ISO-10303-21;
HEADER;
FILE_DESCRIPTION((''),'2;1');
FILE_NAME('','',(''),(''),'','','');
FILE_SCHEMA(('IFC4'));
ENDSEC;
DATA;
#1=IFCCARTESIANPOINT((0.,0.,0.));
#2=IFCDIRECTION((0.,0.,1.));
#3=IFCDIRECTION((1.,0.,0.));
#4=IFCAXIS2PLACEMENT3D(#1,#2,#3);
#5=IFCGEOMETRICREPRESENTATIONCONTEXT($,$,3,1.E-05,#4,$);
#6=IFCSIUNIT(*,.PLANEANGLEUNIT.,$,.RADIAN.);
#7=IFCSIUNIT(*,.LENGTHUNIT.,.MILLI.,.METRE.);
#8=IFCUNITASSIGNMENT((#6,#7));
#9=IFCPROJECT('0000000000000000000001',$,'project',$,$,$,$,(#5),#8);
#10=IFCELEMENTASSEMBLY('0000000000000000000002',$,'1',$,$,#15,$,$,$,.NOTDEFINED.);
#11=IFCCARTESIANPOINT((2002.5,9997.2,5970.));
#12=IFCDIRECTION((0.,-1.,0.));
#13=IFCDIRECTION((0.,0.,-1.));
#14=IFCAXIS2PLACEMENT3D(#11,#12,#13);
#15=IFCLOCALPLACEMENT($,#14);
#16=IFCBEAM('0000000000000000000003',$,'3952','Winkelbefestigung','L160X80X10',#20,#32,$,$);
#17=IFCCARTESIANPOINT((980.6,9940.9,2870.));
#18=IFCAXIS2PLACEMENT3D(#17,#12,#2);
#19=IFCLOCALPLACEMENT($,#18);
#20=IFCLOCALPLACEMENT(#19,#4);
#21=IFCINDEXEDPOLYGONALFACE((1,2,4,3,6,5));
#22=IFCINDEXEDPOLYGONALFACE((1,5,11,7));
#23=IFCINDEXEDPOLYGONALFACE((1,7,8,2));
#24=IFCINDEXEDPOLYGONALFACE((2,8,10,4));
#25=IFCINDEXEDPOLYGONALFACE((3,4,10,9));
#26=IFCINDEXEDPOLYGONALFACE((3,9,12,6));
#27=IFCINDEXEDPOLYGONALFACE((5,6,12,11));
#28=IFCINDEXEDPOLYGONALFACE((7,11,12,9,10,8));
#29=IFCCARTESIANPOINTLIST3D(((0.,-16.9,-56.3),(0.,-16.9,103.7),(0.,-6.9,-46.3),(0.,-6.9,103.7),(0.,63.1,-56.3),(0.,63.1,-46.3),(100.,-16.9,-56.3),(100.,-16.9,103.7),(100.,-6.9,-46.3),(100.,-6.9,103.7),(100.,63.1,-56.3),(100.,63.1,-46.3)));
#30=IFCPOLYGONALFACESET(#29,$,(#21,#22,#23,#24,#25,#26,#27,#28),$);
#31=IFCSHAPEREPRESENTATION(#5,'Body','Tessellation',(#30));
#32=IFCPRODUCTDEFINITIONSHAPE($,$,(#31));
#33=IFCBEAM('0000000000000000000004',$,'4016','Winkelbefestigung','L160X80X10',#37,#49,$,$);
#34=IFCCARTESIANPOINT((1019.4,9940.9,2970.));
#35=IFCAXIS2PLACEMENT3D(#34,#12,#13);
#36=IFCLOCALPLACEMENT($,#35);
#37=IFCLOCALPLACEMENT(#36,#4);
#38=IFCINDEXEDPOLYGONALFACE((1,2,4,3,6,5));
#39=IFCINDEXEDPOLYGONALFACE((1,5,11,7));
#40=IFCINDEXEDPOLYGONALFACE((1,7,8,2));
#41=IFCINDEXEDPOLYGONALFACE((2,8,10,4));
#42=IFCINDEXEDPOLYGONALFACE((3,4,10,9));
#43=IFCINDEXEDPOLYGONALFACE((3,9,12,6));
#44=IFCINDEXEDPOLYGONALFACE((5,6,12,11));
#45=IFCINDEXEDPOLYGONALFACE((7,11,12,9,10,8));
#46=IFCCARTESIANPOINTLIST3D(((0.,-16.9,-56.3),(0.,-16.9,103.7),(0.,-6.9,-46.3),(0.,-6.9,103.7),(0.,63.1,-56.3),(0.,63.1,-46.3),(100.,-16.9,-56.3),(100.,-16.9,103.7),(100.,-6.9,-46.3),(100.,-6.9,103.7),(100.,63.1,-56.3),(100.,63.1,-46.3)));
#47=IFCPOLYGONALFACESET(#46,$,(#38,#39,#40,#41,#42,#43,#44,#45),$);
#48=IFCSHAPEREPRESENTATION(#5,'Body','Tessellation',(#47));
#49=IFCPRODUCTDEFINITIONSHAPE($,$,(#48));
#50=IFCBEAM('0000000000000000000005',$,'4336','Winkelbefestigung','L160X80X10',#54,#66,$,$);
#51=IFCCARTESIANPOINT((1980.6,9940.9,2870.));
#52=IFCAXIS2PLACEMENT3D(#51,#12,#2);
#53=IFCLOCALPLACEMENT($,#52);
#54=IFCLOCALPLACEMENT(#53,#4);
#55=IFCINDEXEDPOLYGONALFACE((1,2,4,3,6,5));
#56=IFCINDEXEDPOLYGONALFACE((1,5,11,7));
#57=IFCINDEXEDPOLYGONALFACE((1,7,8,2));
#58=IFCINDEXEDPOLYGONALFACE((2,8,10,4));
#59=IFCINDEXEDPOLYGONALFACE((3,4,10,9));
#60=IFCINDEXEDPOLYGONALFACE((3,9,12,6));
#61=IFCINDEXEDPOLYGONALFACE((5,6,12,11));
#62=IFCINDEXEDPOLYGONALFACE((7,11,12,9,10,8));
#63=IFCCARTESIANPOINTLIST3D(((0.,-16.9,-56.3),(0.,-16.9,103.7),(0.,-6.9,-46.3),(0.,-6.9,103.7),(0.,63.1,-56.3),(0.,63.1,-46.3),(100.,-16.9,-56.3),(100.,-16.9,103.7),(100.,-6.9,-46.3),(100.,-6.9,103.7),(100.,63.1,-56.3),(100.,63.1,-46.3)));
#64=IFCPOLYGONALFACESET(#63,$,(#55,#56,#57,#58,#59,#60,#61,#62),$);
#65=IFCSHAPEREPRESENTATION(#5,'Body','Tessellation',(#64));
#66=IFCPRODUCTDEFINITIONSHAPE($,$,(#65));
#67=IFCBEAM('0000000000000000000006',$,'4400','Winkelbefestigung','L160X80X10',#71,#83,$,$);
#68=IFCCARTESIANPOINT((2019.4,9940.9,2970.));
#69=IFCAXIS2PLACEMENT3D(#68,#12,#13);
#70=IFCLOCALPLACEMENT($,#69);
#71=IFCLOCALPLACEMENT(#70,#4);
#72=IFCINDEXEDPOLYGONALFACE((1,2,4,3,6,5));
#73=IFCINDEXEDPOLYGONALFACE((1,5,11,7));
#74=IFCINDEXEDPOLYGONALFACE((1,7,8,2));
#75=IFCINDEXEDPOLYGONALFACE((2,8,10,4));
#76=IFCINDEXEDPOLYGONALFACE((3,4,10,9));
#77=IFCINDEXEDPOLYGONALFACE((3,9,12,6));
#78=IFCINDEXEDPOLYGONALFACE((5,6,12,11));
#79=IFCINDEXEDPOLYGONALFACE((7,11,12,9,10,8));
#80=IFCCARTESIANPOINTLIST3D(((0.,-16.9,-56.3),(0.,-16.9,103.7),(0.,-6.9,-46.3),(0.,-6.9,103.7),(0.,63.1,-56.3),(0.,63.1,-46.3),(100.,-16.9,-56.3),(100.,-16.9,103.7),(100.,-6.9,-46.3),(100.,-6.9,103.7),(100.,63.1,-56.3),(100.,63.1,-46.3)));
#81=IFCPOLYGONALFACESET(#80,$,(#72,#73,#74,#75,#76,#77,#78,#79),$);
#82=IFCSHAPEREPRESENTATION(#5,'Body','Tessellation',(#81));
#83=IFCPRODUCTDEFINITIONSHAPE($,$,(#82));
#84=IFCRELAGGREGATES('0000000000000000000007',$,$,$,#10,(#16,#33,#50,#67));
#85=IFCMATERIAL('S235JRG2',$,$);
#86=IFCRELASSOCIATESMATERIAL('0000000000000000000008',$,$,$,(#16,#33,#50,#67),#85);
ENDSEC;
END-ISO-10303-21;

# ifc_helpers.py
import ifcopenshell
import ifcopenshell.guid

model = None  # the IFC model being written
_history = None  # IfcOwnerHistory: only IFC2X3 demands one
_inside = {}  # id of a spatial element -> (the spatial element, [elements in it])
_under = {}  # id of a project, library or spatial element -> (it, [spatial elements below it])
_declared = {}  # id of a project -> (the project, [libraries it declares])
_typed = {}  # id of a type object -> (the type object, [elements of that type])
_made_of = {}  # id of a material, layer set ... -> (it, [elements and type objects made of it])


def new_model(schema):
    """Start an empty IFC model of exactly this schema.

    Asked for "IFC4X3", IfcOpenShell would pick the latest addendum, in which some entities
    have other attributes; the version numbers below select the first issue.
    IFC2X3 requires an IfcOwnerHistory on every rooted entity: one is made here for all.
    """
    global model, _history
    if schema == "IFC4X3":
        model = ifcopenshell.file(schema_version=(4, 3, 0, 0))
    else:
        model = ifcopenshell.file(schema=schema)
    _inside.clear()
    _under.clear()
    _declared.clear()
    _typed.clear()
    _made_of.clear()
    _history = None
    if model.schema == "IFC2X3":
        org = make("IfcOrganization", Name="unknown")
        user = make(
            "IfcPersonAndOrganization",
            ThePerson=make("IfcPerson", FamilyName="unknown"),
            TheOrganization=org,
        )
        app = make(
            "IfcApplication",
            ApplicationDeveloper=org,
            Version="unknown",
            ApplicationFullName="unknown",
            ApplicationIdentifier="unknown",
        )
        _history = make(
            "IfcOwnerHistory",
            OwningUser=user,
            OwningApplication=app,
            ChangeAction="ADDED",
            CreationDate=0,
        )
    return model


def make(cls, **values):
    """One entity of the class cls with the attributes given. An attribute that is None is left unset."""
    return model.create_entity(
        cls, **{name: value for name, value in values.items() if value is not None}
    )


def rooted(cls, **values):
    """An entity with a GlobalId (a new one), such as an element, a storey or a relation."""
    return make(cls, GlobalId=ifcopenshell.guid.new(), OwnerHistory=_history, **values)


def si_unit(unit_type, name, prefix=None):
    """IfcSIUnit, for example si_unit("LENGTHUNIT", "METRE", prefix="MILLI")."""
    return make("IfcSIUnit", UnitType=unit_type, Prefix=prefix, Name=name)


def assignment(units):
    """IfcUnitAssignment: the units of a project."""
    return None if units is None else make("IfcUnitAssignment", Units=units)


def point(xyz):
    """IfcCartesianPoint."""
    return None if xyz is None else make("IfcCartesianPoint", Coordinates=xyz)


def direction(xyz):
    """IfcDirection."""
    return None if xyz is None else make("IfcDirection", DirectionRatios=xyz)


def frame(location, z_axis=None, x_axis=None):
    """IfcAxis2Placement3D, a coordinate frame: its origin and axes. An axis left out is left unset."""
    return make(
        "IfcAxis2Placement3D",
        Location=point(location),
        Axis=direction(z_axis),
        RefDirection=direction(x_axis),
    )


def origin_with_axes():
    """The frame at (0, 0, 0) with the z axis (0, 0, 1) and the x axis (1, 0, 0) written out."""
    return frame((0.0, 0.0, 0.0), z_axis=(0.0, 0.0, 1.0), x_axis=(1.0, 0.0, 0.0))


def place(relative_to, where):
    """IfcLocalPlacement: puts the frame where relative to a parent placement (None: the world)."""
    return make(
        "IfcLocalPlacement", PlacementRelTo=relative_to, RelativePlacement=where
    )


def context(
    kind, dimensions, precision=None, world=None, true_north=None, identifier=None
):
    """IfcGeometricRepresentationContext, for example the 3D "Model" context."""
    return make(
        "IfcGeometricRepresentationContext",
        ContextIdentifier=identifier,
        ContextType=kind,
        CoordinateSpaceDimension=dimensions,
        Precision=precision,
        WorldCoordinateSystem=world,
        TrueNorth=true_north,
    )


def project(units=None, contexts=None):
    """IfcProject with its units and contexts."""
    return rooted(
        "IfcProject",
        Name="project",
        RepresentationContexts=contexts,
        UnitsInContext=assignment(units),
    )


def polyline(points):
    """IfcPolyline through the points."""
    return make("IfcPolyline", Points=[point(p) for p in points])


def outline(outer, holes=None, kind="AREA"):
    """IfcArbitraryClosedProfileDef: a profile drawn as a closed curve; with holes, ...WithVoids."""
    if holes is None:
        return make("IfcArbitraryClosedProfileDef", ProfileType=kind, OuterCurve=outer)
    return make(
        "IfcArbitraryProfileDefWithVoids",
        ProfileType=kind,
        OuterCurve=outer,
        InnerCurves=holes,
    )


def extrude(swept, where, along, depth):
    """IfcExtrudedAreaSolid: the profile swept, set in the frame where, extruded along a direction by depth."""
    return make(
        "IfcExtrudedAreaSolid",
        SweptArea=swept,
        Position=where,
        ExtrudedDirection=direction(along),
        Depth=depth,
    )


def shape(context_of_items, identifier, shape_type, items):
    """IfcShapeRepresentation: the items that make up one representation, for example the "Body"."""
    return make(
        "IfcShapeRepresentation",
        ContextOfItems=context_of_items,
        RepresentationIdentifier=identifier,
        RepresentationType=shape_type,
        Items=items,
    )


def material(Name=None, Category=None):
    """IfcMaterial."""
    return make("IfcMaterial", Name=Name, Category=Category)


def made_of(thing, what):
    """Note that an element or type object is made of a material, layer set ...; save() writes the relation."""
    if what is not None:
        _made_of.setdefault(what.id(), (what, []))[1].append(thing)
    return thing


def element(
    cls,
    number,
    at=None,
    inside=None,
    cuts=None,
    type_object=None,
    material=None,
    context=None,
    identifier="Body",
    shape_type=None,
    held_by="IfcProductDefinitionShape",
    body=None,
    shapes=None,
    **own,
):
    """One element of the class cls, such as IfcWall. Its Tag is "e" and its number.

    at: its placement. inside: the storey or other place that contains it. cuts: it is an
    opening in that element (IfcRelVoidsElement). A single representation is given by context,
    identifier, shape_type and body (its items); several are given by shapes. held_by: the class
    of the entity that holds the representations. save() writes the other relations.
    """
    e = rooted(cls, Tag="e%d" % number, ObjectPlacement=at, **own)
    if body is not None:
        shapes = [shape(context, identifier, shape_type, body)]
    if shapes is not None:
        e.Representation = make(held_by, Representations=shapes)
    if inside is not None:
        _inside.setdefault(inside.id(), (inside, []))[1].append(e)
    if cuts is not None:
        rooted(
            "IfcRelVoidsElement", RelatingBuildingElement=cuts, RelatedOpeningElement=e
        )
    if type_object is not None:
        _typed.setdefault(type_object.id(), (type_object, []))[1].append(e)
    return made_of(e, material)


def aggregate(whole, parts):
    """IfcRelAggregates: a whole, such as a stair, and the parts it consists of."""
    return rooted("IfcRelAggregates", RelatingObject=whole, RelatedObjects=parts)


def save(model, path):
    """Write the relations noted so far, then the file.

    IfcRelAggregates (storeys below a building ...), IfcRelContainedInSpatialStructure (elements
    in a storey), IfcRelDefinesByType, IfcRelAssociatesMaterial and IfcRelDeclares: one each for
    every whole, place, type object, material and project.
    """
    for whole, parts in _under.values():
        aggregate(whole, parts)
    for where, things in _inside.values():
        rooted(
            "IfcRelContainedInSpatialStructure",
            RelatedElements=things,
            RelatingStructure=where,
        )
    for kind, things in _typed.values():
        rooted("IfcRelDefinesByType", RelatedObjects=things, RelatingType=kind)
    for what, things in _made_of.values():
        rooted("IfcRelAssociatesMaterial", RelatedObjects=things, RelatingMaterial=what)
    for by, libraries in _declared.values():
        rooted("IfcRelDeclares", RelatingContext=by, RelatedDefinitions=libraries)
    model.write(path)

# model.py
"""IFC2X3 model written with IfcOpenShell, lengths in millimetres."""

from ifc_helpers import new_model, si_unit, frame, origin_with_axes, place, context, project, polyline, outline, extrude, material, element, aggregate, save


model = new_model("IFC2X3")

# Units and contexts
context_of_model = context(None, 3, precision=1e-05, world=origin_with_axes())
ifc_project = project(units=[si_unit("PLANEANGLEUNIT", "RADIAN"), si_unit("LENGTHUNIT", "METRE", prefix="MILLI")], contexts=[context_of_model])

# Element assembly, beams
assembly_1_placement = place(None, frame((2002.5, 9997.2, 5970.0), z_axis=(0.0, -1.0, 0.0), x_axis=(0.0, 0.0, -1.0)))
assembly_1 = element("IfcElementAssembly", 1, at=assembly_1_placement, Name="1", PredefinedType="NOTDEFINED")
ifc_material = material(Name="S235JRG2")
placement_1 = place(None, frame((980.6, 9940.9, 2870.0), z_axis=(0.0, -1.0, 0.0), x_axis=(0.0, 0.0, 1.0)))
beam_1_placement = place(placement_1, origin_with_axes())
beam_1 = element("IfcBeam", 2, at=beam_1_placement, material=ifc_material, Name="3952", Description="Winkelbefestigung", ObjectType="L160X80X10", context=context_of_model, shape_type="SweptSolid", body=[
    extrude(outline(polyline([(-16.9, 103.7), (-16.9, -56.3), (63.1, -56.3), (63.1, -46.3), (-6.9, -46.3), (-6.9, 103.7), (-16.9, 103.7), (-16.9, 103.7)])), frame((0.0, 0.0, 0.0), z_axis=(1.0, 0.0, 0.0), x_axis=(0.0, 1.0, 0.0)), (0.0, 0.0, 1.0), 100.0),
])
placement_2 = place(None, frame((1019.4, 9940.9, 2970.0), z_axis=(0.0, -1.0, 0.0), x_axis=(0.0, 0.0, -1.0)))
beam_2_placement = place(placement_2, origin_with_axes())
beam_2 = element("IfcBeam", 3, at=beam_2_placement, material=ifc_material, Name="4016", Description="Winkelbefestigung", ObjectType="L160X80X10", context=context_of_model, shape_type="SweptSolid", body=[
    extrude(outline(polyline([(-16.9, 103.7), (-16.9, -56.3), (63.1, -56.3), (63.1, -46.3), (-6.9, -46.3), (-6.9, 103.7), (-16.9, 103.7), (-16.9, 103.7)])), frame((0.0, 0.0, 0.0), z_axis=(1.0, 0.0, 0.0), x_axis=(0.0, 1.0, 0.0)), (0.0, 0.0, 1.0), 100.0),
])
placement_3 = place(None, frame((1980.6, 9940.9, 2870.0), z_axis=(0.0, -1.0, 0.0), x_axis=(0.0, 0.0, 1.0)))
beam_3_placement = place(placement_3, origin_with_axes())
beam_3 = element("IfcBeam", 4, at=beam_3_placement, material=ifc_material, Name="4336", Description="Winkelbefestigung", ObjectType="L160X80X10", context=context_of_model, shape_type="SweptSolid", body=[
    extrude(outline(polyline([(-16.9, 103.7), (-16.9, -56.3), (63.1, -56.3), (63.1, -46.3), (-6.9, -46.3), (-6.9, 103.7), (-16.9, 103.7), (-16.9, 103.7)])), frame((0.0, 0.0, 0.0), z_axis=(1.0, 0.0, 0.0), x_axis=(0.0, 1.0, 0.0)), (0.0, 0.0, 1.0), 100.0),
])
placement_4 = place(None, frame((2019.4, 9940.9, 2970.0), z_axis=(0.0, -1.0, 0.0), x_axis=(0.0, 0.0, -1.0)))
beam_4_placement = place(placement_4, origin_with_axes())
beam_4 = element("IfcBeam", 5, at=beam_4_placement, material=ifc_material, Name="4400", Description="Winkelbefestigung", ObjectType="L160X80X10", context=context_of_model, shape_type="SweptSolid", body=[
    extrude(outline(polyline([(-16.9, 103.7), (-16.9, -56.3), (63.1, -56.3), (63.1, -46.3), (-6.9, -46.3), (-6.9, 103.7), (-16.9, 103.7), (-16.9, 103.7)])), frame((0.0, 0.0, 0.0), z_axis=(1.0, 0.0, 0.0), x_axis=(0.0, 1.0, 0.0)), (0.0, 0.0, 1.0), 100.0),
])
aggregate(assembly_1, [beam_1, beam_2, beam_3, beam_4])

save(model, "model.ifc")
